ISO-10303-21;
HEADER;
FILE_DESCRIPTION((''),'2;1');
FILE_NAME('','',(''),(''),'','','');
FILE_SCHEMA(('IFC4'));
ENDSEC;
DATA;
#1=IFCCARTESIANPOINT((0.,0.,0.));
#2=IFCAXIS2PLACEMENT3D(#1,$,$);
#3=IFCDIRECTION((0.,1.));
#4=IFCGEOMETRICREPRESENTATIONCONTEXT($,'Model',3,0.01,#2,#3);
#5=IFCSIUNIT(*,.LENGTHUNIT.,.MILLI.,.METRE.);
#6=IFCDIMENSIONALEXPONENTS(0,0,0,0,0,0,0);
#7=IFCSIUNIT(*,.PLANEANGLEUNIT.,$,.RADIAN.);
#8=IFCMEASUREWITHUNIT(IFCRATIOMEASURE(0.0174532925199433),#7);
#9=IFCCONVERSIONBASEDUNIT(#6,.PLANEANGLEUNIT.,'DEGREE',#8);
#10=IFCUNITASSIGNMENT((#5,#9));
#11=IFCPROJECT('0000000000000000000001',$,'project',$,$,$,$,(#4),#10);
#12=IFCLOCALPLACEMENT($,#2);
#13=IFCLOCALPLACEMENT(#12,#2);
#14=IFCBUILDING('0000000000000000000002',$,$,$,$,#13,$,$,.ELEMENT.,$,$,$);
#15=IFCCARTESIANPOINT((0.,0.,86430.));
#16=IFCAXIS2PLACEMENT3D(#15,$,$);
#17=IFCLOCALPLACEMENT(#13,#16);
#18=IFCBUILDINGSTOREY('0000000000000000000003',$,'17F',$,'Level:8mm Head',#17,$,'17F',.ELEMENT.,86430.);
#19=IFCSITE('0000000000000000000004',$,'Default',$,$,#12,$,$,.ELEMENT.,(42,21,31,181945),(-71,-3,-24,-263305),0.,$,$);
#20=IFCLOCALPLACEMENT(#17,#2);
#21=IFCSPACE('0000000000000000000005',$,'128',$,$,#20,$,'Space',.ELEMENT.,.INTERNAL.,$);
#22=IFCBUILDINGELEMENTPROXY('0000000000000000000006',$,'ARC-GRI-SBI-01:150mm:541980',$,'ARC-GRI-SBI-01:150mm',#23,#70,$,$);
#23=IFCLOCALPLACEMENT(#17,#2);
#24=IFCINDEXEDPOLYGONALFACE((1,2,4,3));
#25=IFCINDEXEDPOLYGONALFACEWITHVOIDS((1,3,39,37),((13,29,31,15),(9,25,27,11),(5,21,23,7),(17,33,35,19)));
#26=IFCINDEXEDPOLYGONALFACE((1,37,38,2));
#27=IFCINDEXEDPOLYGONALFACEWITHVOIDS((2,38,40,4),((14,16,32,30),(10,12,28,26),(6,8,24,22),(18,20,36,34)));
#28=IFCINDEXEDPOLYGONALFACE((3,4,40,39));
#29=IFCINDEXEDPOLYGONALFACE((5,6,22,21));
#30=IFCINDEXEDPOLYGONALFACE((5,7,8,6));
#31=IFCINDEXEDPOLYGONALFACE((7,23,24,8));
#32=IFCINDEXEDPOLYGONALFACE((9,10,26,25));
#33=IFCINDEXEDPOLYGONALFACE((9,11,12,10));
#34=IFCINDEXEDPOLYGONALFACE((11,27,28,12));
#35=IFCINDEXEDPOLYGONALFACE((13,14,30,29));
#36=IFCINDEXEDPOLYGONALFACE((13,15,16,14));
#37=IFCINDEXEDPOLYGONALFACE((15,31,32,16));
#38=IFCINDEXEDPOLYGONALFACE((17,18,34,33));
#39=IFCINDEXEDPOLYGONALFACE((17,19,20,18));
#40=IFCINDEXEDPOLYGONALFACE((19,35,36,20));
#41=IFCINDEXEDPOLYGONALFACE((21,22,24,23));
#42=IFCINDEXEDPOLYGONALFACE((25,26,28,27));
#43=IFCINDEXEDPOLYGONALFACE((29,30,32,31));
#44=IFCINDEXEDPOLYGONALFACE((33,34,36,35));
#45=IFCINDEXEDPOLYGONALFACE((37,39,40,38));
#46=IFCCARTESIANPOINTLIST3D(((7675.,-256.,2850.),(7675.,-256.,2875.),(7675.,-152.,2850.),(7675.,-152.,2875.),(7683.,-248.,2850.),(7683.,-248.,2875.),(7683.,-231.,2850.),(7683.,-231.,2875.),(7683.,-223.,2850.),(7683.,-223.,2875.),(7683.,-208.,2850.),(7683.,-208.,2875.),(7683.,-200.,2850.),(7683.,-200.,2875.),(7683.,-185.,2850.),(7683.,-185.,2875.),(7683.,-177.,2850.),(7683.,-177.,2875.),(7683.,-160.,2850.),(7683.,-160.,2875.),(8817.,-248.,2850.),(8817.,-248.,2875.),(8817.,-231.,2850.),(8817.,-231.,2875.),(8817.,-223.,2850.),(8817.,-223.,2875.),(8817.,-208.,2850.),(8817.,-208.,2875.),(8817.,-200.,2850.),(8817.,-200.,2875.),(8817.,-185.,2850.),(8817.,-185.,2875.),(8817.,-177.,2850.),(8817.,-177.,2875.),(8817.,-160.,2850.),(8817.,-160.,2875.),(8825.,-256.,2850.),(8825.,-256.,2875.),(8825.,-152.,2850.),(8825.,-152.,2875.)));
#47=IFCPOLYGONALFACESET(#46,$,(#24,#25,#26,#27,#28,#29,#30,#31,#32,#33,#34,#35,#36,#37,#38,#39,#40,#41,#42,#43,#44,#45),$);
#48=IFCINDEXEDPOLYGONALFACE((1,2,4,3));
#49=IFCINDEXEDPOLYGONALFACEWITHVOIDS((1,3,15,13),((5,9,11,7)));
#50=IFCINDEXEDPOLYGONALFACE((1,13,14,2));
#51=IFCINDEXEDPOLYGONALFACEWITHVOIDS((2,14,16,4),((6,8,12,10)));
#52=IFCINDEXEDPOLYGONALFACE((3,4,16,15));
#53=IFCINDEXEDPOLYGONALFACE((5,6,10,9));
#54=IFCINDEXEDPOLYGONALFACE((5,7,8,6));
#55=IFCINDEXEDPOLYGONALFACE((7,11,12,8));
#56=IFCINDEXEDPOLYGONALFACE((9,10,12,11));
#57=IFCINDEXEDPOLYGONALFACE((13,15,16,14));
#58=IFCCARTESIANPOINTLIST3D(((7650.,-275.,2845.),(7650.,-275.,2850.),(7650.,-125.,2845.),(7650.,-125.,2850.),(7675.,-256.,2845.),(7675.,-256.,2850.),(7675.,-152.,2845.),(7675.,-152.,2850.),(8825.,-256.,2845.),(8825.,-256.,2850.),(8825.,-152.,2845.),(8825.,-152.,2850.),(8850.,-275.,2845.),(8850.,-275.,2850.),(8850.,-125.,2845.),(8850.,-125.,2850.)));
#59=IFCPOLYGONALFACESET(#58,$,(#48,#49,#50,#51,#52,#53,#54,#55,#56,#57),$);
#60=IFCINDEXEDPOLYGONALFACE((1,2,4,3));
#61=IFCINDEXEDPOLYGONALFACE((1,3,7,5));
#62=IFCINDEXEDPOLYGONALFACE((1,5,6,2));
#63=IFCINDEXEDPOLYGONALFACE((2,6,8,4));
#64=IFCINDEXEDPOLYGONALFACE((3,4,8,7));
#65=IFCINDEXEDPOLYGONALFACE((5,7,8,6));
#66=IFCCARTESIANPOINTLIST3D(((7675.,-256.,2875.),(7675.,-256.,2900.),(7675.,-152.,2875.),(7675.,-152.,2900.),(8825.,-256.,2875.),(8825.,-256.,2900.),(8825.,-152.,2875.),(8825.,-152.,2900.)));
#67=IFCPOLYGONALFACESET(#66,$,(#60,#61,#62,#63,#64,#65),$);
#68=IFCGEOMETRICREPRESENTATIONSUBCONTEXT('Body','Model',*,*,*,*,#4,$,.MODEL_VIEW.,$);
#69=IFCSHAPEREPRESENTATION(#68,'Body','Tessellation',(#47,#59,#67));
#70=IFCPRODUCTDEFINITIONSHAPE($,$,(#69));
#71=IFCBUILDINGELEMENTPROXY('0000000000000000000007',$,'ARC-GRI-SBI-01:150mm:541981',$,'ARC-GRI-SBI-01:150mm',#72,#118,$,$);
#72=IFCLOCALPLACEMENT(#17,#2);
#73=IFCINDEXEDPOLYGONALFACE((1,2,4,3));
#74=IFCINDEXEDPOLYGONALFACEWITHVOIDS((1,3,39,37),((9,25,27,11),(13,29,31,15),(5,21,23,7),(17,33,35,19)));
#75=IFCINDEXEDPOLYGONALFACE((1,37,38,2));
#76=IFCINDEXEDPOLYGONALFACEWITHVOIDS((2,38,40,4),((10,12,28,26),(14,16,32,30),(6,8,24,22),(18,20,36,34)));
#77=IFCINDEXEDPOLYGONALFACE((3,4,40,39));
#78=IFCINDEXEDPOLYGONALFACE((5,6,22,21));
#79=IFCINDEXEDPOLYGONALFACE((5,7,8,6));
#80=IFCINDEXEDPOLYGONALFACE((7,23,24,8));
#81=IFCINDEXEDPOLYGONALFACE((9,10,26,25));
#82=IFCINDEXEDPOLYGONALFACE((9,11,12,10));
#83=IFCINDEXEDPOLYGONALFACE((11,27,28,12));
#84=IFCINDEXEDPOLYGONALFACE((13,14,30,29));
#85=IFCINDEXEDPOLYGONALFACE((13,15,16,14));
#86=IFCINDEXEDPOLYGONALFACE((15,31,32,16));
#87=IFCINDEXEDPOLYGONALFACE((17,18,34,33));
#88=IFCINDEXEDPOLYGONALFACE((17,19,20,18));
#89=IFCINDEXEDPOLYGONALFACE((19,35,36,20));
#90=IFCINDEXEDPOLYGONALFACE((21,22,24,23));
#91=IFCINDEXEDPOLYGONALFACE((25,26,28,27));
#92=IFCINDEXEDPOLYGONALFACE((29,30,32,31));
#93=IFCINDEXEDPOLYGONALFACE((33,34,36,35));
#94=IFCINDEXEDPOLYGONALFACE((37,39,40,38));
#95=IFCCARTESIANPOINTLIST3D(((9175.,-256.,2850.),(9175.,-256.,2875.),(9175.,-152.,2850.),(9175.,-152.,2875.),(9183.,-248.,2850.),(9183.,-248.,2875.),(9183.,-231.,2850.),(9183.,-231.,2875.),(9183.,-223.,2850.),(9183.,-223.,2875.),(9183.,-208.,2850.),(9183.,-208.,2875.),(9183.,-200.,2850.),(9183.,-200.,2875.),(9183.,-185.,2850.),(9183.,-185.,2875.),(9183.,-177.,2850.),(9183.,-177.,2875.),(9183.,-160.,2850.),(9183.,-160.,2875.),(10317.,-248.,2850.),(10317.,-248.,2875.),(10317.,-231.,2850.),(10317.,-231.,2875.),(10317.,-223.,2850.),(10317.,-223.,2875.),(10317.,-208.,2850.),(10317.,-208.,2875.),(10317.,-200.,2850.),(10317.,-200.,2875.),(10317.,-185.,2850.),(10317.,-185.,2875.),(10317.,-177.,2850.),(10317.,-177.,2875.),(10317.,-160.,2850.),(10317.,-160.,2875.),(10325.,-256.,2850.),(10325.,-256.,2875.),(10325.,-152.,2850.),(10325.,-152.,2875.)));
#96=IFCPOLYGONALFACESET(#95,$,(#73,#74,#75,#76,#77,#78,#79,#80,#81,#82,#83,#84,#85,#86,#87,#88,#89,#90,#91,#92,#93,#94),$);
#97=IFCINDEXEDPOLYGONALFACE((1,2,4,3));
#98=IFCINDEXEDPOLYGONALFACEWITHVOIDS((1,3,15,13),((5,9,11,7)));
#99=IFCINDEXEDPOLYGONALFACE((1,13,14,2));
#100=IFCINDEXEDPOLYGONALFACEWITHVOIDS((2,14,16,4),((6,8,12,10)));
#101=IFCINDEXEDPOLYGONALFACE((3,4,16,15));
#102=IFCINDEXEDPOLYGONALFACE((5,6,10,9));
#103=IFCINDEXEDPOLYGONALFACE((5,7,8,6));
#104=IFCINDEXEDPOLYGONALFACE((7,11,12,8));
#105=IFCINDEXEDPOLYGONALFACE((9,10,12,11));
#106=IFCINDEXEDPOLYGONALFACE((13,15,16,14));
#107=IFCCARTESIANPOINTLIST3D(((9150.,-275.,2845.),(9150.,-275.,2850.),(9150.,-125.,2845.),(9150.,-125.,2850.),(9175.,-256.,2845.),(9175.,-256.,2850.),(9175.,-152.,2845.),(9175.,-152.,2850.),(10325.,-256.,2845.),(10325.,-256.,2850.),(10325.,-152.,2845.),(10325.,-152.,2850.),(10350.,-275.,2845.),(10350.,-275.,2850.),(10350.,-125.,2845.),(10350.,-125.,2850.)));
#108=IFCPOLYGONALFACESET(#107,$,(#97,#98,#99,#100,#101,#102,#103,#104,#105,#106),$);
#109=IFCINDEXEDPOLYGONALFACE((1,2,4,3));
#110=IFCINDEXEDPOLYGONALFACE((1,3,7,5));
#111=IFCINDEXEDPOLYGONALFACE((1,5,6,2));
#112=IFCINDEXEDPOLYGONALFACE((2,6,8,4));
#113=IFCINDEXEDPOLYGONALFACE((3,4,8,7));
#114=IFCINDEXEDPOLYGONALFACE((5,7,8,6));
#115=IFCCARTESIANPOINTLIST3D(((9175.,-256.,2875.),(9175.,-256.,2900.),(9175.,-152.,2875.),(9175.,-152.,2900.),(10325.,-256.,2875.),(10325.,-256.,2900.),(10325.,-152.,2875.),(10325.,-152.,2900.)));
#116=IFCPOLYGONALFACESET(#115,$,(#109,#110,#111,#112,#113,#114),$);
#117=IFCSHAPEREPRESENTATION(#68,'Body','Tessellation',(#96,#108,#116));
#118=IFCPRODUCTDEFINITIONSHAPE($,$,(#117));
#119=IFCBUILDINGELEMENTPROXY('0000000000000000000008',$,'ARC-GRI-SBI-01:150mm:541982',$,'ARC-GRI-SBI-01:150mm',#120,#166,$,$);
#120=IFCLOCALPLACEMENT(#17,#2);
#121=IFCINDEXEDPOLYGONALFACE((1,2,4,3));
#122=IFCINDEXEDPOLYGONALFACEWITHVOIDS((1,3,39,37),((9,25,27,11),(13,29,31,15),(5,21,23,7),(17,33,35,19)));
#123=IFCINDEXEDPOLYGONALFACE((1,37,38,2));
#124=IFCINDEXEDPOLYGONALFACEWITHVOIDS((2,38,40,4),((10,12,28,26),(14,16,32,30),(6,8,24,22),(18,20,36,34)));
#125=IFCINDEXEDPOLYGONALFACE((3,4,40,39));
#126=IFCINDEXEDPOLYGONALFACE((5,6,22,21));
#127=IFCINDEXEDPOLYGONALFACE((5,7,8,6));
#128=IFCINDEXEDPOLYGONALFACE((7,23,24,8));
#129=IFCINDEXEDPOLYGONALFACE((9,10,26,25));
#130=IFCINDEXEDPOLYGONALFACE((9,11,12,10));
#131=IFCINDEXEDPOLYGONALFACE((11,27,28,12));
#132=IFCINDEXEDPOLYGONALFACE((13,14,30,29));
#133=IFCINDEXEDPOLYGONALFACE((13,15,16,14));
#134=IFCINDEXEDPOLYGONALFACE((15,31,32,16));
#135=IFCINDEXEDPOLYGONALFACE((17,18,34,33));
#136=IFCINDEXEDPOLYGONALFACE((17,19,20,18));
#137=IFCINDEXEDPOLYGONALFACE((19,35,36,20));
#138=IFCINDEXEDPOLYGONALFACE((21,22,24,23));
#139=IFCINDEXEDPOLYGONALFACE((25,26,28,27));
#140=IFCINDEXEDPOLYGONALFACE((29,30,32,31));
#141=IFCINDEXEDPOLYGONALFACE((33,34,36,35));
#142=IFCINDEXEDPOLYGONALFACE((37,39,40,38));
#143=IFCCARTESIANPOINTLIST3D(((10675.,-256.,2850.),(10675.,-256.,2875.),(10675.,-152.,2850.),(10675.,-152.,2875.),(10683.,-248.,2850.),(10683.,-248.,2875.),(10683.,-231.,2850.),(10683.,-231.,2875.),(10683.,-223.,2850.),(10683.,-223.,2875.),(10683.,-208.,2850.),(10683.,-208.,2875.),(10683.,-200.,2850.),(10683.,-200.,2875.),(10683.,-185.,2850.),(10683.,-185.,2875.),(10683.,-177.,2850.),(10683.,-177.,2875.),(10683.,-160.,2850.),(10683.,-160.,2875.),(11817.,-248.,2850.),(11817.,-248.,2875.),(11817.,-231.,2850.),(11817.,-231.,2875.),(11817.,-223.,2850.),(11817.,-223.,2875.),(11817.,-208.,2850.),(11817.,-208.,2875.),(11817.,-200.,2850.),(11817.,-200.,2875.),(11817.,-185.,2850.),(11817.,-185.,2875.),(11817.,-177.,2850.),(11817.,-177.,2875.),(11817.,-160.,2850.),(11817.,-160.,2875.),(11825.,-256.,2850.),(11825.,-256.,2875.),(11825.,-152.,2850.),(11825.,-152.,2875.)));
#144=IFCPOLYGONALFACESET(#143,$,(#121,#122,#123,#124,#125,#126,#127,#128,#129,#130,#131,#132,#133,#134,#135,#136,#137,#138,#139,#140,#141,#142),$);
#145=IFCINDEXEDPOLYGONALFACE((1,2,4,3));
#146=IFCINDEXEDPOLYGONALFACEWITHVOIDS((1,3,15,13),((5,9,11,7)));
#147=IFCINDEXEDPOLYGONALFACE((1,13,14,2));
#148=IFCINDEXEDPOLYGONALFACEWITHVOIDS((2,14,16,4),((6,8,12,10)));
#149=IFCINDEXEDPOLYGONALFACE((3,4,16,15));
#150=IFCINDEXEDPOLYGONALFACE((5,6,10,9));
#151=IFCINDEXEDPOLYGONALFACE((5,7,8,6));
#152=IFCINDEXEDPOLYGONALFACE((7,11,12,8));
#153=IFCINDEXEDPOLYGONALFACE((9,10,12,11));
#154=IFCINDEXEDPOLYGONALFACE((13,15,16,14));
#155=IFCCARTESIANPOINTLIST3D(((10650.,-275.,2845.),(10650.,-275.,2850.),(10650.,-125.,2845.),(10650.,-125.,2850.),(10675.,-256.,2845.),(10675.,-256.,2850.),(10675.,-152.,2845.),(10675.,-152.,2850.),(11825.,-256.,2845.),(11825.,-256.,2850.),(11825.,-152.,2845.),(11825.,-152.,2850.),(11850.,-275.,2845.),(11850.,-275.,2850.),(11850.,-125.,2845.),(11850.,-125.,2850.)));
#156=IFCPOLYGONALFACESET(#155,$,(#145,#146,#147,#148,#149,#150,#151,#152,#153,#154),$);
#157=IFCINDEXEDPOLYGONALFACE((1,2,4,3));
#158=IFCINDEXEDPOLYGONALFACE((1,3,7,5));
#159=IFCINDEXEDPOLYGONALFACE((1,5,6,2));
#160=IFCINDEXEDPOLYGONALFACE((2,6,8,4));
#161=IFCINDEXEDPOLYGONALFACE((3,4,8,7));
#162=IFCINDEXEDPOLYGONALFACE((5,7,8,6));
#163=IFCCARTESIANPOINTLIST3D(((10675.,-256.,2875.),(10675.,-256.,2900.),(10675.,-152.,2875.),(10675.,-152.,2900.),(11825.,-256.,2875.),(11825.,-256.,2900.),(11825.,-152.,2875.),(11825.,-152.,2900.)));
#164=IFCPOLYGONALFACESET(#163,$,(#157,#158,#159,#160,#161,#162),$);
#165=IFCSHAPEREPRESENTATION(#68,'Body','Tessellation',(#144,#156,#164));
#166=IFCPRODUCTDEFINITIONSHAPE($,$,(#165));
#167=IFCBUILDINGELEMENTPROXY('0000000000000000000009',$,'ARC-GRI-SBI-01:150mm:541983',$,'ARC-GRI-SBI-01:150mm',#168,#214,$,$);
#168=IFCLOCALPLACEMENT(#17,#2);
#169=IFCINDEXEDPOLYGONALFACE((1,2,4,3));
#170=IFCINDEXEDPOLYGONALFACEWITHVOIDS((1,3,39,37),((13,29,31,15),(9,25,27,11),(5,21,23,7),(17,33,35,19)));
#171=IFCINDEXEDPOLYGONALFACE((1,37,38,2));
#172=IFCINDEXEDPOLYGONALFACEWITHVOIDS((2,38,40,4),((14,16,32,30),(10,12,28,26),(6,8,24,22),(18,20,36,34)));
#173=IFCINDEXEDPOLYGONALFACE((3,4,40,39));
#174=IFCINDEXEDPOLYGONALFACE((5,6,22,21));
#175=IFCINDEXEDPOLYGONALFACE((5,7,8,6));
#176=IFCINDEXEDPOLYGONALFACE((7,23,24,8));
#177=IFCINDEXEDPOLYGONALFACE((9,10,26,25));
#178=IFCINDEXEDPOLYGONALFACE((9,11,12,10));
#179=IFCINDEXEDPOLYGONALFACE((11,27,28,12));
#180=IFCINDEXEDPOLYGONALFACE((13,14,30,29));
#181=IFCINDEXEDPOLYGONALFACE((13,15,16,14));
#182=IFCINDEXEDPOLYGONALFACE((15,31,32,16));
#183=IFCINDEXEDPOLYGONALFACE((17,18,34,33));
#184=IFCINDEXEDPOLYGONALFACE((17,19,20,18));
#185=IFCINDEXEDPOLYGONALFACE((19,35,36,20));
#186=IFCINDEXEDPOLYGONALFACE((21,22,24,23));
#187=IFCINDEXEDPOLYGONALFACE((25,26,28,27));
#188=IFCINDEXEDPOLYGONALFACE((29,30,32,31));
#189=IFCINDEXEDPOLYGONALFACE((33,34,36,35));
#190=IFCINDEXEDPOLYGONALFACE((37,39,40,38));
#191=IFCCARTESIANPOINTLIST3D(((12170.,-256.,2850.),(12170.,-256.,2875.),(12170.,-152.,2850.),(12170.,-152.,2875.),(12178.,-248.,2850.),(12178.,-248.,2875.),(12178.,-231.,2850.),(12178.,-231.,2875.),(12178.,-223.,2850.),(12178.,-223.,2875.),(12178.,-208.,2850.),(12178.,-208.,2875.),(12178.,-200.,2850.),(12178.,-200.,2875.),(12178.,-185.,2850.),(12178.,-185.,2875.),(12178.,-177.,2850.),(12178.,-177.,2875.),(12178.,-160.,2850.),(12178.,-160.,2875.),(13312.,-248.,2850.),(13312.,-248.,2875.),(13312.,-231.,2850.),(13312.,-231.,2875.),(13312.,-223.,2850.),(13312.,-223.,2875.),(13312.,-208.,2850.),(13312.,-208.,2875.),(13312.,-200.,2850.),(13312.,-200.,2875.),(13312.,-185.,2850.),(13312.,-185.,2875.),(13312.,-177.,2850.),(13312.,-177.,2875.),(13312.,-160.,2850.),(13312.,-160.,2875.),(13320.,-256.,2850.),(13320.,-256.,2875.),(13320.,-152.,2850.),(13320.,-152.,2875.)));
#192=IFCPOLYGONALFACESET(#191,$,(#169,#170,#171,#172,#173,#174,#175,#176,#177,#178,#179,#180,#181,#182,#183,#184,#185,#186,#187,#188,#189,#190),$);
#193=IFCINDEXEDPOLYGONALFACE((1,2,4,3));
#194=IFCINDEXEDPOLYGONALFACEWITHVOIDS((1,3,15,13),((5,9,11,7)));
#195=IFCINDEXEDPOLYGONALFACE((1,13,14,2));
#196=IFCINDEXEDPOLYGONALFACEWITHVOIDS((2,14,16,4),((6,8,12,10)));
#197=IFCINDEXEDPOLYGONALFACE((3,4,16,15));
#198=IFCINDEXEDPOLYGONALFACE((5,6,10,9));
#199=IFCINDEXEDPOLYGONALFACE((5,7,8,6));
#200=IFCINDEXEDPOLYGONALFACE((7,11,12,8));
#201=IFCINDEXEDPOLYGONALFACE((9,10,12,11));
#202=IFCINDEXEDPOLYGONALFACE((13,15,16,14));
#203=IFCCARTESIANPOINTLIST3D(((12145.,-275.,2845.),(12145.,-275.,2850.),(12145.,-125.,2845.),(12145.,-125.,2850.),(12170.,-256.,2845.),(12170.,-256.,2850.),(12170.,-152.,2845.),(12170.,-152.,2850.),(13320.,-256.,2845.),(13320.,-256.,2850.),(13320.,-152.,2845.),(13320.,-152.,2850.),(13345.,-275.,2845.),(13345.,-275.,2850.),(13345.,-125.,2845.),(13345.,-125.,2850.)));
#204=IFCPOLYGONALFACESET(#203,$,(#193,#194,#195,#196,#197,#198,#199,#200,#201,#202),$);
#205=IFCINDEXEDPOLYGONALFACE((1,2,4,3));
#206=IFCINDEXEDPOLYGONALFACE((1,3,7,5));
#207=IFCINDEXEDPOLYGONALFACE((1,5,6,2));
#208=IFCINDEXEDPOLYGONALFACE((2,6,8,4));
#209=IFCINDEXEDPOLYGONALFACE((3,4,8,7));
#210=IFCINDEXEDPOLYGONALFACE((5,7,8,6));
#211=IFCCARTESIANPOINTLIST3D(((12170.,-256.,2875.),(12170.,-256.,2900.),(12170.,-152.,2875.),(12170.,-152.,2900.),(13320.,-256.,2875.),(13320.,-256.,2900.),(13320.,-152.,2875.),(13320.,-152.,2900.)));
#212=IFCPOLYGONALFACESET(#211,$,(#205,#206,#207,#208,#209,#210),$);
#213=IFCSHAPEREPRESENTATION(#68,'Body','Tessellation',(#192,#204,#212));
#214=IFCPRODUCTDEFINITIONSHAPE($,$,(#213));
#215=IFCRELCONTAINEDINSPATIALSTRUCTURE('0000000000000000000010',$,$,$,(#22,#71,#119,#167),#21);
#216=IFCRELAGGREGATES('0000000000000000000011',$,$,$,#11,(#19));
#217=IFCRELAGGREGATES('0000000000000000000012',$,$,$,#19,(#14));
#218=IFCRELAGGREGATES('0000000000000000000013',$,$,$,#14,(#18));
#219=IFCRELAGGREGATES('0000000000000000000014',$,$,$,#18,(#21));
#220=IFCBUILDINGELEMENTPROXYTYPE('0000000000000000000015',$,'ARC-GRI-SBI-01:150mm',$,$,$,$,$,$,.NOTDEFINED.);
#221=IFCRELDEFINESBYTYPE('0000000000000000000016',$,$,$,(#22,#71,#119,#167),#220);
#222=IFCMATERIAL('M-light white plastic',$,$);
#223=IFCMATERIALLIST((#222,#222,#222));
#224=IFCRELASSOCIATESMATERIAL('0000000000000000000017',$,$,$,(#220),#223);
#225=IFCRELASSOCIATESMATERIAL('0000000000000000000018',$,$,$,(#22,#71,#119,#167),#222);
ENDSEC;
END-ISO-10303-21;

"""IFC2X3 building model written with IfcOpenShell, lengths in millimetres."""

from ifc_helpers import new_model, entity, si_unit, converted_unit, direction, frame, origin, origin_2d_with_axis, place, context, subcontext, project, spatial, polyline, rectangle, outline, extrude, source, transform, mapped, material, material_list, type_object, type_shapes, element, save


model = new_model("IFC2X3")

# Units and contexts
model_context = context("Model", 3, precision=0.01, world=origin(), true_north=direction((0.0, 1.0)))
body_context = subcontext(model_context, "Body", "Model", "MODEL_VIEW")
ifc_project = project(units=[si_unit("LENGTHUNIT", "METRE", prefix="MILLI"), converted_unit("PLANEANGLEUNIT", "DEGREE", entity("IfcRatioMeasure", 0.0174532925199433), si_unit("PLANEANGLEUNIT", "RADIAN"), dimensions=[0, 0, 0, 0, 0, 0, 0])], contexts=[model_context])

# Site, building, storey
site_placement = place(None, origin())
site = spatial("IfcSite", under=ifc_project, at=site_placement, Name="Default", CompositionType="ELEMENT", RefLatitude=(42, 21, 31, 181945), RefLongitude=(-71, -3, -24, -263305), RefElevation=0.0)
building_placement = place(site_placement, origin())
building = spatial("IfcBuilding", under=site, at=building_placement, CompositionType="ELEMENT")
storey_placement = place(building_placement, frame((0.0, 0.0, 86430.0)))
storey = spatial("IfcBuildingStorey", under=building, at=storey_placement, Name="17F", ObjectType="Level:8mm Head", LongName="17F", CompositionType="ELEMENT", Elevation=86430.0)

# Shared definitions
space_placement = place(storey_placement, origin())
space = spatial("IfcSpace", under=storey, at=space_placement, Name="128", LongName="Space", CompositionType="ELEMENT", InteriorOrExteriorSpace="INTERNAL")

# Building element proxies
ifc_material_1 = material(Name="M-light white plastic")
ifc_material_list = material_list([ifc_material_1, ifc_material_1, ifc_material_1])
building_element_proxy_type = type_object("IfcBuildingElementProxyType", Name="ARC-GRI-SBI-01:150mm", PredefinedType="NOTDEFINED", material=ifc_material_list)
shared_shape = source(origin(), body_context, "Body", "SweptSolid", [
    extrude(outline(polyline([(-575.0, -52.0), (575.0, -52.0), (575.0, 52.0), (-575.0, 52.0), (-575.0, -52.0)]), holes=[polyline([(-567.0, -44.0), (-567.0, -27.0), (567.0, -27.0), (567.0, -44.0), (-567.0, -44.0)]), polyline([(567.0, -4.0), (567.0, -19.0), (-567.0, -19.0), (-567.0, -4.0), (567.0, -4.0)]), polyline([(-567.0, 44.0), (567.0, 44.0), (567.0, 27.0), (-567.0, 27.0), (-567.0, 44.0)]), polyline([(567.0, 4.0), (-567.0, 4.0), (-567.0, 19.0), (567.0, 19.0), (567.0, 4.0)])]), frame((425.0, 4.0, 4000.0), z_axis=(0.0, 0.0, 1.0), x_axis=(-1.0, 0.0, 0.0)), (0.0, 0.0, 1.0), 25.0),
    extrude(outline(polyline([(-600.0, -75.0), (600.0, -75.0), (600.0, 75.0), (-600.0, 75.0), (-600.0, -75.0)]), holes=[polyline([(-575.0, -56.0), (-575.0, 48.0), (575.0, 48.0), (575.0, -56.0), (-575.0, -56.0)])]), frame((425.0, 0.0, 3995.0), z_axis=(0.0, 0.0, 1.0), x_axis=(-1.0, 0.0, 0.0)), (0.0, 0.0, 1.0), 5.0),
    extrude(rectangle(XDim=1150.0, YDim=104.0, at=origin_2d_with_axis()), frame((425.0, 4.0, 4025.0), z_axis=(0.0, 0.0, 1.0), x_axis=(-1.0, 0.0, 0.0)), (0.0, 0.0, 1.0), 25.0),
])
type_shapes(building_element_proxy_type, [shared_shape])
for number, where, z_axis, x_axis, name in (
    (1, (8675.0, -200.0, -1150.0), (0.0, 0.0, 1.0), (-1.0, 0.0, 0.0), "ARC-GRI-SBI-01:150mm:541980"),
    (2, (10175.0, -200.0, -1150.0), (0.0, 0.0, 1.0), (-1.0, 0.0, 0.0), "ARC-GRI-SBI-01:150mm:541981"),
    (3, (11675.0, -200.0, -1150.0), (0.0, 0.0, 1.0), (-1.0, 0.0, 0.0), "ARC-GRI-SBI-01:150mm:541982"),
    (4, (13170.0, -200.0, -1150.0), (0.0, 0.0, 1.0), (-1.0, 0.0, 0.0), "ARC-GRI-SBI-01:150mm:541983"),
):
    element("IfcBuildingElementProxy", number, at=place(space_placement, frame(where, z_axis=z_axis, x_axis=x_axis)), inside=space, type_object=building_element_proxy_type, material=ifc_material_1, Name=name, ObjectType="ARC-GRI-SBI-01:150mm", context=body_context, shape_type="MappedRepresentation", body=[
        mapped(shared_shape, transform((0.0, 0.0, 0.0), scale=1.0)),
    ])

save(model, "model.ifc")
